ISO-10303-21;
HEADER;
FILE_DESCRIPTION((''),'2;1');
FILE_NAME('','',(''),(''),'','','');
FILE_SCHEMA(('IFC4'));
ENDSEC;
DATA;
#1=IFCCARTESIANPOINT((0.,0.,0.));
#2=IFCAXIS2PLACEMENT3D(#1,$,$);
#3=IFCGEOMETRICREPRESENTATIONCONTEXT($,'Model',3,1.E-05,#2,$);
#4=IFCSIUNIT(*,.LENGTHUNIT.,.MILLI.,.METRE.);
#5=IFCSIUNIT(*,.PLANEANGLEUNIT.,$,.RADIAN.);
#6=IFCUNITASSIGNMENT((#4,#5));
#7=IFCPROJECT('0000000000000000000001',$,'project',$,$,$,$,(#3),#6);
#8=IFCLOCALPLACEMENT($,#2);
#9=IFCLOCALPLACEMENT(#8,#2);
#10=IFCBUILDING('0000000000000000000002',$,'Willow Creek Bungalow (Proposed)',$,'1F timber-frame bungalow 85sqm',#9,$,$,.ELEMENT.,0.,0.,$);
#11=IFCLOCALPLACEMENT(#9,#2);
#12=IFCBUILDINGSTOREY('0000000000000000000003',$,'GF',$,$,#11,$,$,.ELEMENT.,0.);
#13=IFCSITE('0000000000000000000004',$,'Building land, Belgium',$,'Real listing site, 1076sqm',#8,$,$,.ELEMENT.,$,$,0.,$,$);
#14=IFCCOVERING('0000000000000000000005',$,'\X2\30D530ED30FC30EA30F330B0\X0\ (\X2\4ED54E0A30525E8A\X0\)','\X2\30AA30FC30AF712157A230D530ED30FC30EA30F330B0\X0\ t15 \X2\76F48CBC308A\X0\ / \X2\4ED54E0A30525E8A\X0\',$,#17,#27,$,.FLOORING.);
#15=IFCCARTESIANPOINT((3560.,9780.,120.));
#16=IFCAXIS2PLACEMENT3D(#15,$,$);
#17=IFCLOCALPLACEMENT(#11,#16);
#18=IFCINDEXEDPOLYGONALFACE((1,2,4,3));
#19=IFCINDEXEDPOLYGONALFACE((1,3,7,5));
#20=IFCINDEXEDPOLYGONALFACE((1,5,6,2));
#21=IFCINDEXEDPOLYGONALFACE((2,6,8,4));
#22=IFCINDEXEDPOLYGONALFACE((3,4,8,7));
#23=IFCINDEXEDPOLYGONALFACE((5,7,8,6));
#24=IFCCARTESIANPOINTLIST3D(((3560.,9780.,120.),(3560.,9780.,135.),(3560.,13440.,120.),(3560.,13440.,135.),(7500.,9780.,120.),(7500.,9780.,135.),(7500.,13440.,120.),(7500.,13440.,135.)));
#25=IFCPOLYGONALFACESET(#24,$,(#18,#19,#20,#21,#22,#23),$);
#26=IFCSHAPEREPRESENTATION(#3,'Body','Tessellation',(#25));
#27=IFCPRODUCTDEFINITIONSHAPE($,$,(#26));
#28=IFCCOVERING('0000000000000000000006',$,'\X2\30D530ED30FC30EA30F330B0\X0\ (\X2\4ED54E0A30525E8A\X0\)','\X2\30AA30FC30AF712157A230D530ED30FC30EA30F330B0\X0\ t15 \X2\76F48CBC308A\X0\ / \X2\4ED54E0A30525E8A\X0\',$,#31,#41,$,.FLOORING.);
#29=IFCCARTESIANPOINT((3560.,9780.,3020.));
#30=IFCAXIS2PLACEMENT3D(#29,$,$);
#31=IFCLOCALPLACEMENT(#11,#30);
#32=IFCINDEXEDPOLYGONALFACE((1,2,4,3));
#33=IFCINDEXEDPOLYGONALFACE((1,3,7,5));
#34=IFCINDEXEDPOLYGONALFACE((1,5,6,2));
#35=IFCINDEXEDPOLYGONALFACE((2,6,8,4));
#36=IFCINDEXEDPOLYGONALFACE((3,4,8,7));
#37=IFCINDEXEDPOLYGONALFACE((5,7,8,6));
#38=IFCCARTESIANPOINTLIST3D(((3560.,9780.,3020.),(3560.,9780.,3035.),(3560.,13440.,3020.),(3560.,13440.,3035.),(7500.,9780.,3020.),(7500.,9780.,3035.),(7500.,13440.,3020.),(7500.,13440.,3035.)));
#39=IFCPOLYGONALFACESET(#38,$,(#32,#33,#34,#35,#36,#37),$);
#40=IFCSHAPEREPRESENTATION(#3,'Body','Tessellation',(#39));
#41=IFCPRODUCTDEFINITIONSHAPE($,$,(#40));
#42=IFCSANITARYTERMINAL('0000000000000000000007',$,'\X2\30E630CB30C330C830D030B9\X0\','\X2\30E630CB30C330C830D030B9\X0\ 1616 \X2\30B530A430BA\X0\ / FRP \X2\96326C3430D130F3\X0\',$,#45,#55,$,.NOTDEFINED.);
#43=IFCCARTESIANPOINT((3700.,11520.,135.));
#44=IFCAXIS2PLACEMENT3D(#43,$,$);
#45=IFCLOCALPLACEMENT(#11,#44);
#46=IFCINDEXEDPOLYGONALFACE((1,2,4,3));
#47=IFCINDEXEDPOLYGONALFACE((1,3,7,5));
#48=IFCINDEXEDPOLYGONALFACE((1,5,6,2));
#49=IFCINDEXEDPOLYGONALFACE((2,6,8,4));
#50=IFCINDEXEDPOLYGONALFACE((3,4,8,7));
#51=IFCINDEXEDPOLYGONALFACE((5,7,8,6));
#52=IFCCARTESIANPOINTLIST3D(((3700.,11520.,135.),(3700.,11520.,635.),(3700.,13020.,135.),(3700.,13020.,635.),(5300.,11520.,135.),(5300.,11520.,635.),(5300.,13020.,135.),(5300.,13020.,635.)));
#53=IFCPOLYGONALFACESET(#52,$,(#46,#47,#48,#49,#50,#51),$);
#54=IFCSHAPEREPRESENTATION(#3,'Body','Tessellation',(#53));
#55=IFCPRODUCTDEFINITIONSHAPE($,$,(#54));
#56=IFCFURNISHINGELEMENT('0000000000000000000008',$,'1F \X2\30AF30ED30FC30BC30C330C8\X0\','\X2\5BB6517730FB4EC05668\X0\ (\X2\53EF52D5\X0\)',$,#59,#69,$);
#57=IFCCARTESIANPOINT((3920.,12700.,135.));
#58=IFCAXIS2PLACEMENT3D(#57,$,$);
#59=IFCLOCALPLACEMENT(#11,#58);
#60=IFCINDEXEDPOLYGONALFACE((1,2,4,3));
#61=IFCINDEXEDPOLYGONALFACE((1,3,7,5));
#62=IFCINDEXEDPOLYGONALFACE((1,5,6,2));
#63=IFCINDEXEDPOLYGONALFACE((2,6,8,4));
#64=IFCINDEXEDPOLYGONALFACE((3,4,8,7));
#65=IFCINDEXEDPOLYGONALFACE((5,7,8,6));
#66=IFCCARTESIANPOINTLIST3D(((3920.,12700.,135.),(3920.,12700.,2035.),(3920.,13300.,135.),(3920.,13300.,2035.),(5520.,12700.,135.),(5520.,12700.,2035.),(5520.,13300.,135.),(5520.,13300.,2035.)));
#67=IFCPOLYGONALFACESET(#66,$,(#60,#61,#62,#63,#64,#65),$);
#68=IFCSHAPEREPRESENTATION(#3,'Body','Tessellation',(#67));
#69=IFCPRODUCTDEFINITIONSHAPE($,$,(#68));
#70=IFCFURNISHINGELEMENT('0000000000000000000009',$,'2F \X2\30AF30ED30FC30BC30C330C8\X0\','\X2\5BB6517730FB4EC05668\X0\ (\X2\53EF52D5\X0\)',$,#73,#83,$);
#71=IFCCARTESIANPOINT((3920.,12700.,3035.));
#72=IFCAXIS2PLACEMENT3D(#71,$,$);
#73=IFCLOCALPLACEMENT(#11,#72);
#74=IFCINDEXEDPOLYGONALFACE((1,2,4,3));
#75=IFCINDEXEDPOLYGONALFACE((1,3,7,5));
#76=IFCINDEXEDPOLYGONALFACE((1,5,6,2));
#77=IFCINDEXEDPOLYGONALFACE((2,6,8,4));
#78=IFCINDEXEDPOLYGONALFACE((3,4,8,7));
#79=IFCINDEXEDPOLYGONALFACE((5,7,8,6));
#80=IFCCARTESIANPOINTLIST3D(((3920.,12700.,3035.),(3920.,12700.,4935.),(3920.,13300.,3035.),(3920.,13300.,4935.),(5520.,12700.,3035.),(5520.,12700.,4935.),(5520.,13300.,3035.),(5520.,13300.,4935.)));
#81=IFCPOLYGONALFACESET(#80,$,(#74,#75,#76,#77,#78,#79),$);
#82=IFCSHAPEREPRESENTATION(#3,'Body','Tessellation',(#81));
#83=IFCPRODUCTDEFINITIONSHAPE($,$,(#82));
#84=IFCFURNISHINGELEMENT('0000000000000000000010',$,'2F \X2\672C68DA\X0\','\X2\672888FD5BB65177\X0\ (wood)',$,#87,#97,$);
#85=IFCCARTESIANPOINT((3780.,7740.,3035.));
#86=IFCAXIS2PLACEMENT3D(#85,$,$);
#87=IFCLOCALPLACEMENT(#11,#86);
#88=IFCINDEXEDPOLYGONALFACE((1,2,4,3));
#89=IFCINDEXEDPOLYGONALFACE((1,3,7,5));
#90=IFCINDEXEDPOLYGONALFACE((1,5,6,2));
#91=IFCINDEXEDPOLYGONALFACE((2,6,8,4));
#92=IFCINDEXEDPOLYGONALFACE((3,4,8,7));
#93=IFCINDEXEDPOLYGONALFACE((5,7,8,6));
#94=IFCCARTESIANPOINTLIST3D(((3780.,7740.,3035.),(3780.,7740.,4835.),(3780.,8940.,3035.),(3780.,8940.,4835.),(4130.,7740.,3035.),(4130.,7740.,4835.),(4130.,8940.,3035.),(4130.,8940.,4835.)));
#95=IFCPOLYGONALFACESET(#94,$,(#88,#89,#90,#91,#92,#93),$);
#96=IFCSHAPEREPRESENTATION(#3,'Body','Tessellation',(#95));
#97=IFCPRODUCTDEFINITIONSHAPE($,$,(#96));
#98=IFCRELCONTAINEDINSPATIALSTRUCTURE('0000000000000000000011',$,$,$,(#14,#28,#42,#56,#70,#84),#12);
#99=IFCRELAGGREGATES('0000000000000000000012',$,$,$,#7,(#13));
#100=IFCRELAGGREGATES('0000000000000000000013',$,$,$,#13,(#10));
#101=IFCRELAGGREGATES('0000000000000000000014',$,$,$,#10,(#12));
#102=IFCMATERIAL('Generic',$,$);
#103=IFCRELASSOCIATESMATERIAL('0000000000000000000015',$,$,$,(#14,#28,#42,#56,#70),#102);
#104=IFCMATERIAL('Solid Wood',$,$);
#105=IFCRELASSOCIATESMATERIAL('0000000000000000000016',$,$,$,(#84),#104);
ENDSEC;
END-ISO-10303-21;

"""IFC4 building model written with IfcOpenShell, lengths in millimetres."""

from ifc_helpers import new_model, si_unit, frame, frame_2d, origin, place, context, project, spatial, rectangle, extrude, material, element, save


model = new_model("IFC4")

# Units and contexts
model_context = context("Model", 3, precision=1e-05, world=origin())
ifc_project = project(units=[si_unit("LENGTHUNIT", "METRE", prefix="MILLI"), si_unit("PLANEANGLEUNIT", "RADIAN")], contexts=[model_context])

# Site, building, storey
site_placement = place(None, origin())
site = spatial("IfcSite", under=ifc_project, at=site_placement, Name="Building land, Belgium", ObjectType="Real listing site, 1076sqm", CompositionType="ELEMENT", RefElevation=0.0)
building_placement = place(site_placement, origin())
building = spatial("IfcBuilding", under=site, at=building_placement, Name="Willow Creek Bungalow (Proposed)", ObjectType="1F timber-frame bungalow 85sqm", CompositionType="ELEMENT", ElevationOfRefHeight=0.0, ElevationOfTerrain=0.0)
storey_placement = place(building_placement, origin())
storey = spatial("IfcBuildingStorey", under=building, at=storey_placement, Name="GF", CompositionType="ELEMENT", Elevation=0.0)

# Shared definitions
ifc_material_1 = material(Name="Solid Wood")

# Coverings
ifc_material_2 = material(Name="Generic")
covering_1_placement = place(storey_placement, frame((3560.0, 9780.0, 120.0)))
element("IfcCovering", 1, at=covering_1_placement, inside=storey, material=ifc_material_2, Name="フローリング (仕上げ床)", Description="オーク無垢フローリング t15 直貼り / 仕上げ床", PredefinedType="FLOORING", context=model_context, shape_type="SweptSolid", body=[
    extrude(rectangle(XDim=3940.0, YDim=3660.0, at=frame_2d((1970.0, 1830.0))), frame((3560.0, 9780.0, 120.0)), (0.0, 0.0, 1.0), 15.0),
])
covering_2_placement = place(storey_placement, frame((3560.0, 9780.0, 3020.0)))
element("IfcCovering", 2, at=covering_2_placement, inside=storey, material=ifc_material_2, Name="フローリング (仕上げ床)", Description="オーク無垢フローリング t15 直貼り / 仕上げ床", PredefinedType="FLOORING", context=model_context, shape_type="SweptSolid", body=[
    extrude(rectangle(XDim=3940.0, YDim=3660.0, at=frame_2d((1970.0, 1830.0))), frame((3560.0, 9780.0, 3020.0)), (0.0, 0.0, 1.0), 15.0),
])

# Sanitary terminal
sanitary_terminal_placement = place(storey_placement, frame((3700.0, 11520.0, 135.0)))
element("IfcSanitaryTerminal", 3, at=sanitary_terminal_placement, inside=storey, material=ifc_material_2, Name="ユニットバス", Description="ユニットバス 1616 サイズ / FRP 防水パン", PredefinedType="NOTDEFINED", context=model_context, shape_type="SweptSolid", body=[
    extrude(rectangle(XDim=1600.0, YDim=1500.0, at=frame_2d((800.0, 750.0))), frame((3700.0, 11520.0, 135.0)), (0.0, 0.0, 1.0), 500.0),
])

# Furnishing elements
furnishing_1_placement = place(storey_placement, frame((3920.0, 12700.0, 135.0)))
element("IfcFurnishingElement", 4, at=furnishing_1_placement, inside=storey, material=ifc_material_2, Name="1F クローゼット", Description="家具・什器 (可動)", context=model_context, shape_type="SweptSolid", body=[
    extrude(rectangle(XDim=1600.0, YDim=600.0, at=frame_2d((800.0, 300.0))), frame((3920.0, 12700.0, 135.0)), (0.0, 0.0, 1.0), 1900.0),
])
furnishing_2_placement = place(storey_placement, frame((3920.0, 12700.0, 3035.0)))
element("IfcFurnishingElement", 5, at=furnishing_2_placement, inside=storey, material=ifc_material_2, Name="2F クローゼット", Description="家具・什器 (可動)", context=model_context, shape_type="SweptSolid", body=[
    extrude(rectangle(XDim=1600.0, YDim=600.0, at=frame_2d((800.0, 300.0))), frame((3920.0, 12700.0, 3035.0)), (0.0, 0.0, 1.0), 1900.0),
])
furnishing_3_placement = place(storey_placement, frame((3780.0, 7740.0, 3035.0)))
element("IfcFurnishingElement", 6, at=furnishing_3_placement, inside=storey, material=ifc_material_1, Name="2F 本棚", Description="木製家具 (wood)", context=model_context, shape_type="SweptSolid", body=[
    extrude(rectangle(XDim=350.0, YDim=1200.0, at=frame_2d((175.0, 600.0))), frame((3780.0, 7740.0, 3035.0)), (0.0, 0.0, 1.0), 1800.0),
])

save(model, "model.ifc")
